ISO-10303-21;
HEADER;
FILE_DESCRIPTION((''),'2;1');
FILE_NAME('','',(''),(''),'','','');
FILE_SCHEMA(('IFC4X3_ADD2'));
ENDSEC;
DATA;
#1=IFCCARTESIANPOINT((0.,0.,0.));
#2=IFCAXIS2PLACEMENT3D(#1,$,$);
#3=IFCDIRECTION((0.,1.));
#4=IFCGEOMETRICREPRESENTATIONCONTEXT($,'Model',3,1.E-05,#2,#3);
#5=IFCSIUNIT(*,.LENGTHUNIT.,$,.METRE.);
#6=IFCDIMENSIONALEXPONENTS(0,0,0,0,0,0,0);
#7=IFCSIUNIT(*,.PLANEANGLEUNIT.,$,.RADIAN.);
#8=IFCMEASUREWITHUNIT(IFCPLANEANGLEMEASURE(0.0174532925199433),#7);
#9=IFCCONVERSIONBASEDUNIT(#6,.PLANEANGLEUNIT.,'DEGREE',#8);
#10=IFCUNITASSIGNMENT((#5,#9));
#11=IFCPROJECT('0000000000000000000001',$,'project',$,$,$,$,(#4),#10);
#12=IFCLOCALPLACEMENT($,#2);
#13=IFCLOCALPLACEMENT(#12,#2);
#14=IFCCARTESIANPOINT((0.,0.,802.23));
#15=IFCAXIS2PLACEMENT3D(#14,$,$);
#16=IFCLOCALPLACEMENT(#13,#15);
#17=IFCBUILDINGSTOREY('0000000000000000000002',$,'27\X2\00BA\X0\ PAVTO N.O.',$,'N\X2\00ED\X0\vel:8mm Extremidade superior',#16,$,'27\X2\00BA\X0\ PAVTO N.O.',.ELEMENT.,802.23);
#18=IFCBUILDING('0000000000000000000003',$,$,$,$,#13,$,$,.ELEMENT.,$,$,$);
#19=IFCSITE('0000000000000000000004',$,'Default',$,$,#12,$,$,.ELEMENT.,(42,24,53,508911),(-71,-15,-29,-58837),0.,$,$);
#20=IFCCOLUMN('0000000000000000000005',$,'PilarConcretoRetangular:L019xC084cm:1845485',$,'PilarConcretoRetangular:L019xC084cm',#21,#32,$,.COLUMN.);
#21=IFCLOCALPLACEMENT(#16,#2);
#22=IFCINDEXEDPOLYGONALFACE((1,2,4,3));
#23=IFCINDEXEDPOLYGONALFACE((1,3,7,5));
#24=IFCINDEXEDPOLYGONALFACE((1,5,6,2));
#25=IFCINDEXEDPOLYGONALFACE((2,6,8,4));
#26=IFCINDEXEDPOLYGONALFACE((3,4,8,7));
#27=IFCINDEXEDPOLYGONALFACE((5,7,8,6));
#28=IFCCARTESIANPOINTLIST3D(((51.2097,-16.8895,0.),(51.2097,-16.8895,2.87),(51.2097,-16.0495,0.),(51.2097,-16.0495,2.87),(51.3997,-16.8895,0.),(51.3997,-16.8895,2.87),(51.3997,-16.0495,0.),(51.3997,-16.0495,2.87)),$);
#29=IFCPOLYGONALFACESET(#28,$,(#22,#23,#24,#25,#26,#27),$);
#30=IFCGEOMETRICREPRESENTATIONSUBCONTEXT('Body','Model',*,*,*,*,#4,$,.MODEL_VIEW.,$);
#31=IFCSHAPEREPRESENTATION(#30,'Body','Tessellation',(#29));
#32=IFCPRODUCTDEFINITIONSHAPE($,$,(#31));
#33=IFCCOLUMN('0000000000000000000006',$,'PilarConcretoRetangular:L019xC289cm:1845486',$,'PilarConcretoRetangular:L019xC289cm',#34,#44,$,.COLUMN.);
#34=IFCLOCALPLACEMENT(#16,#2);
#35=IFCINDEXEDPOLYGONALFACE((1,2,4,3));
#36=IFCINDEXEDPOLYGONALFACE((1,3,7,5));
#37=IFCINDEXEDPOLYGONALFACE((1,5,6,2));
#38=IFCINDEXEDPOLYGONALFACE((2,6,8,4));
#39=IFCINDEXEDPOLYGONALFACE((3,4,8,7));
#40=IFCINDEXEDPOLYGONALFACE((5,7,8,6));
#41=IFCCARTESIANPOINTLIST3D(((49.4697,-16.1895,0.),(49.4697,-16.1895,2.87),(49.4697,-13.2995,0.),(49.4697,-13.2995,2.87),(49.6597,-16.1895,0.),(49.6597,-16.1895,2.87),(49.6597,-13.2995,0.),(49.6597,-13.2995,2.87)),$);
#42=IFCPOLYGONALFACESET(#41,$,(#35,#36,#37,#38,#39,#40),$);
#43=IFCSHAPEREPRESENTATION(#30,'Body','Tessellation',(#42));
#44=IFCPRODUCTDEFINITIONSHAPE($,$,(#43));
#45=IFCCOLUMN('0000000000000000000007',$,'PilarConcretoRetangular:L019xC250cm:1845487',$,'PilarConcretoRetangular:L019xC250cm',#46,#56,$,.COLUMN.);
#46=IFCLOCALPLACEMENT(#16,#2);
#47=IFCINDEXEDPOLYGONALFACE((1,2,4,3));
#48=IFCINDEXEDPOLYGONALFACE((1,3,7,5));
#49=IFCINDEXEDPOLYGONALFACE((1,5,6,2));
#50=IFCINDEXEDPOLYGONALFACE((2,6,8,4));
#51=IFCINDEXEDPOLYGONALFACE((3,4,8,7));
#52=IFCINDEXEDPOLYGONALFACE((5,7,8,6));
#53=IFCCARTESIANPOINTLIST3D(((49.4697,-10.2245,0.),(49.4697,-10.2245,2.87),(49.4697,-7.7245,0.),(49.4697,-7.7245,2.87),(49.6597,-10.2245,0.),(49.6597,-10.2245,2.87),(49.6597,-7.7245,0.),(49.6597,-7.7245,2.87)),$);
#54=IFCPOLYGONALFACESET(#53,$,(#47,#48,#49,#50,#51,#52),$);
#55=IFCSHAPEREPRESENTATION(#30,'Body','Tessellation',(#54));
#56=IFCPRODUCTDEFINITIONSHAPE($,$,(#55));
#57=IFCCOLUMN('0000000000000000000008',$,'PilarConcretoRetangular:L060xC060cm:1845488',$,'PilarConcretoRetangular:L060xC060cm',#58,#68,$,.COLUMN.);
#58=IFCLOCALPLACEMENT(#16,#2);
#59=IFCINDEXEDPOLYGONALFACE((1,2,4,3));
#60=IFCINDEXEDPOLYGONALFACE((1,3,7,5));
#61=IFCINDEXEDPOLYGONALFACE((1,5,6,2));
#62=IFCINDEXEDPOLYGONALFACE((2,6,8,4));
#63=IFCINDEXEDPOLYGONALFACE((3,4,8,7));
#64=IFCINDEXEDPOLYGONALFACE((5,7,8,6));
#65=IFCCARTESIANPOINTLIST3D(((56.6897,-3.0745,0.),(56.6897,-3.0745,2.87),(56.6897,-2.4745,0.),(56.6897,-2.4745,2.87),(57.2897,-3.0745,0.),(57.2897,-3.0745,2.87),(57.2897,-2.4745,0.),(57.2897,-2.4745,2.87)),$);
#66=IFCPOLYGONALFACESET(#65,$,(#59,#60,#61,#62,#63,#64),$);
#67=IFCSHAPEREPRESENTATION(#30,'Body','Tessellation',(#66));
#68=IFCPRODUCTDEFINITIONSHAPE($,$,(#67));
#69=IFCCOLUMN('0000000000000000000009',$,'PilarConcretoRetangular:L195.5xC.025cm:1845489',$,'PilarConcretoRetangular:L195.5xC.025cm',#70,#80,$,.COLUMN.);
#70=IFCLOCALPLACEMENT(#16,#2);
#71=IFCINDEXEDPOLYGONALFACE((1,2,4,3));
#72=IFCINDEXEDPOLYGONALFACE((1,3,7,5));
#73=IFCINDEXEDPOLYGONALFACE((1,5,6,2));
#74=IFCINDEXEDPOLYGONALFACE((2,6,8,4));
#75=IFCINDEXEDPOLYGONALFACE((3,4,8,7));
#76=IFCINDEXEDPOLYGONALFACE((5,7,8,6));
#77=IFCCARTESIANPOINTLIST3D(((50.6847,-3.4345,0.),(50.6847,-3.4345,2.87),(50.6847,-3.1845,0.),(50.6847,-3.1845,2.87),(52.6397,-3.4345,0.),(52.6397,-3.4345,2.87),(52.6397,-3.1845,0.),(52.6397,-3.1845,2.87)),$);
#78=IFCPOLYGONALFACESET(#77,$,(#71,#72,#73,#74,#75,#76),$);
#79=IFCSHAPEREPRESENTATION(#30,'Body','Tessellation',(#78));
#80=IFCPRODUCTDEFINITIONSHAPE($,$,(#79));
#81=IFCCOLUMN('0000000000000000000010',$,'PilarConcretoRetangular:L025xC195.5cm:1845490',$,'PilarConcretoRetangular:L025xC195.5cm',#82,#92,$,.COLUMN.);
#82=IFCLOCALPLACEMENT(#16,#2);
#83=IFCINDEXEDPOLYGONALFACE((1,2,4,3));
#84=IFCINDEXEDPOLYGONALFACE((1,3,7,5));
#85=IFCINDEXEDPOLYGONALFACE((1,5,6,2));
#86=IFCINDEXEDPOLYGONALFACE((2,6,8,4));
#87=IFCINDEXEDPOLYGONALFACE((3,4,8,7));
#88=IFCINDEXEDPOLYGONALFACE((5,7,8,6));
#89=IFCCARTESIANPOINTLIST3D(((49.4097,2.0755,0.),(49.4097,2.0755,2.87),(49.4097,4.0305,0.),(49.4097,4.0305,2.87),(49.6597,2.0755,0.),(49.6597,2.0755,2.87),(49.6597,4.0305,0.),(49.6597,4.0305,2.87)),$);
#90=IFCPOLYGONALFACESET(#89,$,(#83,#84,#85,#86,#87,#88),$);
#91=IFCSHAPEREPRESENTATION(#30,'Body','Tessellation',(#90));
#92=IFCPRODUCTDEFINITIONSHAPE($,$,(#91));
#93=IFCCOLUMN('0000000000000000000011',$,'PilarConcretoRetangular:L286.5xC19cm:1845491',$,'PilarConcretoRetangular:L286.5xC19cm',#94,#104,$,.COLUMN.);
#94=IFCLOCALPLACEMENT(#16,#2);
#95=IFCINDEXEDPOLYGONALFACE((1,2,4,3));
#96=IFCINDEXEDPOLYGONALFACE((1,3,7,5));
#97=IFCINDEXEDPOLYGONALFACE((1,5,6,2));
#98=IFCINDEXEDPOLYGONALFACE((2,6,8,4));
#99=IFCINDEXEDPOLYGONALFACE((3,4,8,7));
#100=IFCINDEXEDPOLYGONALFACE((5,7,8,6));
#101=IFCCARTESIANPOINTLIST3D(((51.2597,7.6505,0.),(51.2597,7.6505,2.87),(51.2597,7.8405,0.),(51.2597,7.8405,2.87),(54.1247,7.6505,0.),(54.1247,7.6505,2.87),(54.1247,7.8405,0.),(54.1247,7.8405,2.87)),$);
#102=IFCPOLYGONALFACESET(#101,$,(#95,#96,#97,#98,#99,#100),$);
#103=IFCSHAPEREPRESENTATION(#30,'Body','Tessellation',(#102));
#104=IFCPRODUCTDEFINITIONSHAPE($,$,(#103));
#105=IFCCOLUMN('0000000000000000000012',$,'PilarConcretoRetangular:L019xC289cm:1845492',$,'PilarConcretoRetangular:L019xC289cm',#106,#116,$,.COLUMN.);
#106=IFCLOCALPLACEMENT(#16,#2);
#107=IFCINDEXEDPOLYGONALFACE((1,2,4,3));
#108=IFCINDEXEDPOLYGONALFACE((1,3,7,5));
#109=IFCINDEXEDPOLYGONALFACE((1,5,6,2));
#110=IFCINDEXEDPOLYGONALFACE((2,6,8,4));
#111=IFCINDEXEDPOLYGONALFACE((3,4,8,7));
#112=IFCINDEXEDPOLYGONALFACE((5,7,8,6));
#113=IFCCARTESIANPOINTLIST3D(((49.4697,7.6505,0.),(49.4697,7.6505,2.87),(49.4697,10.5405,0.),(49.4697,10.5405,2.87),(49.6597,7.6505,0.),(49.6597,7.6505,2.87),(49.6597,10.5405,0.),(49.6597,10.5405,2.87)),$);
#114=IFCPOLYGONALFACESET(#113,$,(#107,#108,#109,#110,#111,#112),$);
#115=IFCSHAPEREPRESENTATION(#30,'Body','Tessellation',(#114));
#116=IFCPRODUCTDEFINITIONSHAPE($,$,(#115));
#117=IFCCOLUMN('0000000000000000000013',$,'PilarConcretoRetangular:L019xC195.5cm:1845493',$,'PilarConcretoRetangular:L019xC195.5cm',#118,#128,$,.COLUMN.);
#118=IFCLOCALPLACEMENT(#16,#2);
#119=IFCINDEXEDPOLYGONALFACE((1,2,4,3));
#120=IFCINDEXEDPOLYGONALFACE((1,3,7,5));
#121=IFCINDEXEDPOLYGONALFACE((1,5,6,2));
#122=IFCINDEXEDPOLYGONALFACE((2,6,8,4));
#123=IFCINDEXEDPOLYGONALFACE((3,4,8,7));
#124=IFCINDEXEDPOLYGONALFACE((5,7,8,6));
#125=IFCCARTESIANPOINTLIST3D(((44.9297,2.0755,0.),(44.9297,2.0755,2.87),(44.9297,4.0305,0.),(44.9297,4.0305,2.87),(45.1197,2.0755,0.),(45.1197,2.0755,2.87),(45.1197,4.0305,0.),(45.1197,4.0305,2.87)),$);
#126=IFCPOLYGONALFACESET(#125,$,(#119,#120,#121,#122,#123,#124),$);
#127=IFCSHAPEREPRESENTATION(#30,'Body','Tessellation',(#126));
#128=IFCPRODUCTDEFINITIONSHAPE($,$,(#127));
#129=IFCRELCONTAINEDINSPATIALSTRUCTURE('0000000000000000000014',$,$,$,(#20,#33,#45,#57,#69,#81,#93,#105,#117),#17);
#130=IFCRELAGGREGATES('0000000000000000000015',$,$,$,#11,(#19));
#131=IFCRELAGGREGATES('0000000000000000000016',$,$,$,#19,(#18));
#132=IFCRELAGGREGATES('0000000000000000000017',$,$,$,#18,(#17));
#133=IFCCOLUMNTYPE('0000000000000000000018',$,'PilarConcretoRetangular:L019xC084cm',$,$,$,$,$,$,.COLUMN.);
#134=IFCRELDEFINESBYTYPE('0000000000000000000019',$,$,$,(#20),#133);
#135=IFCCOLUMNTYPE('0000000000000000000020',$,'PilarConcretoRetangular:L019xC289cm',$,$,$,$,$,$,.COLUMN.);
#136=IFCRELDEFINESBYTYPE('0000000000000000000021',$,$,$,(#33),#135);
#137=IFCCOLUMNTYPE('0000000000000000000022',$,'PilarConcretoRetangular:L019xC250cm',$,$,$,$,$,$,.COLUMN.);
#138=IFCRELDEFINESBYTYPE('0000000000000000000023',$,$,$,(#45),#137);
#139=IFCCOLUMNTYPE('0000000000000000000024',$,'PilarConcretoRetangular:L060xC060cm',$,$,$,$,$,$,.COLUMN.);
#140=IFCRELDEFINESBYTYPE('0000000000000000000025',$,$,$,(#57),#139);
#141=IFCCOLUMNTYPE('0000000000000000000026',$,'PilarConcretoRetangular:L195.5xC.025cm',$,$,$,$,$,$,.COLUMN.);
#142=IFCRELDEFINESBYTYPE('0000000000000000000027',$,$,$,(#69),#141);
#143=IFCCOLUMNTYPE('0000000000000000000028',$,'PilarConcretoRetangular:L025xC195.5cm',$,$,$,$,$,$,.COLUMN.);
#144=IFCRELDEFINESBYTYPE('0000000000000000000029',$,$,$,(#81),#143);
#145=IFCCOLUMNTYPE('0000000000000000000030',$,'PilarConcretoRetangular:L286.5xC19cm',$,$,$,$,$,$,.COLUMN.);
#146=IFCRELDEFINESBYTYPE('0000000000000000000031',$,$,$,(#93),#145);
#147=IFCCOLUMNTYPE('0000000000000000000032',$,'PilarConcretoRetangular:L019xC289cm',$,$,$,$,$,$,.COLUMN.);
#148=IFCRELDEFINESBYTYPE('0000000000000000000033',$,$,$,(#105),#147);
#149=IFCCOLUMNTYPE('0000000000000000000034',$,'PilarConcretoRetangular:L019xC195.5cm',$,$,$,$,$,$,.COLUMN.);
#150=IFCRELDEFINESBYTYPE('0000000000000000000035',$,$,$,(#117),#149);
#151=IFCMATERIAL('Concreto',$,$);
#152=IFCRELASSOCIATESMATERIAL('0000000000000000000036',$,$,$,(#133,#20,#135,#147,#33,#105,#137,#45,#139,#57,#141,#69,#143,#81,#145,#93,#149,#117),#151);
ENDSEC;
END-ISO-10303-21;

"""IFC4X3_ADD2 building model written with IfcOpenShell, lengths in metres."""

from ifc_helpers import new_model, entity, si_unit, converted_unit, direction, frame, frame_2d, origin, origin_2d_with_axis, place, context, subcontext, project, spatial, rectangle, extrude, source, transform, mapped, material, material_profile, profile_set, profile_usage, type_object, type_shapes, element, save


model = new_model("IFC4X3_ADD2")

# Units and contexts
model_context = context("Model", 3, precision=1e-05, world=origin(), true_north=direction((0.0, 1.0)))
body_context = subcontext(model_context, "Body", "Model", "MODEL_VIEW")
ifc_project = project(units=[si_unit("LENGTHUNIT", "METRE"), converted_unit("PLANEANGLEUNIT", "DEGREE", entity("IfcPlaneAngleMeasure", 0.0174532925199433), si_unit("PLANEANGLEUNIT", "RADIAN"), dimensions=[0, 0, 0, 0, 0, 0, 0])], contexts=[model_context])

# Site, building, storey
site_placement = place(None, origin())
site = spatial("IfcSite", under=ifc_project, at=site_placement, Name="Default", CompositionType="ELEMENT", RefLatitude=(42, 24, 53, 508911), RefLongitude=(-71, -15, -29, -58837), RefElevation=0.0)
building_placement = place(site_placement, origin())
building = spatial("IfcBuilding", under=site, at=building_placement, CompositionType="ELEMENT")
storey_placement = place(building_placement, frame((0.0, 0.0, 802.23)))
storey = spatial("IfcBuildingStorey", under=building, at=storey_placement, Name="27º PAVTO N.O.", ObjectType="Nível:8mm Extremidade superior", LongName="27º PAVTO N.O.", CompositionType="ELEMENT", Elevation=802.23)

# Columns
ifc_material = material(Name="Concreto")
ifc_material_profile_1 = material_profile(ifc_material, rectangle(XDim=0.19, YDim=0.84, at=frame_2d((0.0, 0.0), x_axis=(1.0, 0.0))), Name="L019xC084cm")
ifc_profile_set_1 = profile_set([ifc_material_profile_1], Name="L019xC084cm")
ifc_profile_usage_1 = profile_usage(ifc_profile_set_1)
column_type_1 = type_object("IfcColumnType", Name="PilarConcretoRetangular:L019xC084cm", PredefinedType="COLUMN", material=ifc_profile_set_1)
shared_shape_1 = source(origin(), body_context, "Body", "SweptSolid", [
    extrude(rectangle(XDim=0.19, YDim=0.84, at=frame_2d((0.0, 0.0), x_axis=(1.0, 0.0))), frame((51.3047, -16.4695, 802.23), z_axis=(0.0, 0.0, 1.0), x_axis=(-1.0, 0.0, 0.0)), (0.0, 0.0, 1.0), 2.87),
])
type_shapes(column_type_1, [shared_shape_1])
column_1_placement = place(storey_placement, frame((0.0, 0.0, -802.23)))
element("IfcColumn", 1, at=column_1_placement, inside=storey, type_object=column_type_1, material=ifc_profile_usage_1, Name="PilarConcretoRetangular:L019xC084cm:1845485", ObjectType="PilarConcretoRetangular:L019xC084cm", PredefinedType="COLUMN", context=body_context, shape_type="MappedRepresentation", body=[
    mapped(shared_shape_1, transform((0.0, 0.0, 0.0), scale=1.0)),
])
ifc_material_profile_2 = material_profile(ifc_material, rectangle(XDim=0.19, YDim=2.89, at=frame_2d((0.0, 0.0), x_axis=(1.0, 0.0))), Name="L019xC289cm")
ifc_profile_set_2 = profile_set([ifc_material_profile_2], Name="L019xC289cm")
ifc_profile_usage_2 = profile_usage(ifc_profile_set_2)
column_type_2 = type_object("IfcColumnType", Name="PilarConcretoRetangular:L019xC289cm", PredefinedType="COLUMN", material=ifc_profile_set_2)
shared_shape_2 = source(origin(), body_context, "Body", "SweptSolid", [
    extrude(rectangle(XDim=0.19, YDim=2.89, at=frame_2d((0.0, 0.0), x_axis=(1.0, 0.0))), frame((49.5647, -14.7445, 802.23), z_axis=(0.0, 0.0, 1.0), x_axis=(-1.0, 0.0, 0.0)), (0.0, 0.0, 1.0), 2.87),
])
type_shapes(column_type_2, [shared_shape_2])
column_2_placement = place(storey_placement, frame((0.0, 0.0, -802.23)))
element("IfcColumn", 2, at=column_2_placement, inside=storey, type_object=column_type_2, material=ifc_profile_usage_2, Name="PilarConcretoRetangular:L019xC289cm:1845486", ObjectType="PilarConcretoRetangular:L019xC289cm", PredefinedType="COLUMN", context=body_context, shape_type="MappedRepresentation", body=[
    mapped(shared_shape_2, transform((0.0, 0.0, 0.0), scale=1.0)),
])
ifc_material_profile_3 = material_profile(ifc_material, rectangle(XDim=0.19, YDim=2.5, at=frame_2d((0.0, 0.0), x_axis=(1.0, 0.0))), Name="L019xC250cm")
ifc_profile_set_3 = profile_set([ifc_material_profile_3], Name="L019xC250cm")
ifc_profile_usage_3 = profile_usage(ifc_profile_set_3)
column_type_3 = type_object("IfcColumnType", Name="PilarConcretoRetangular:L019xC250cm", PredefinedType="COLUMN", material=ifc_profile_set_3)
shared_shape_3 = source(origin(), body_context, "Body", "SweptSolid", [
    extrude(rectangle(XDim=0.19, YDim=2.5, at=frame_2d((0.0, 0.0), x_axis=(1.0, 0.0))), frame((49.5647, -8.9745, 802.23), z_axis=(0.0, 0.0, 1.0), x_axis=(-1.0, 0.0, 0.0)), (0.0, 0.0, 1.0), 2.87),
])
type_shapes(column_type_3, [shared_shape_3])
column_3_placement = place(storey_placement, frame((0.0, 0.0, -802.23)))
element("IfcColumn", 3, at=column_3_placement, inside=storey, type_object=column_type_3, material=ifc_profile_usage_3, Name="PilarConcretoRetangular:L019xC250cm:1845487", ObjectType="PilarConcretoRetangular:L019xC250cm", PredefinedType="COLUMN", context=body_context, shape_type="MappedRepresentation", body=[
    mapped(shared_shape_3, transform((0.0, 0.0, 0.0), scale=1.0)),
])
ifc_material_profile_4 = material_profile(ifc_material, rectangle(XDim=0.6, YDim=0.6, at=origin_2d_with_axis()), Name="L060xC060cm")
ifc_profile_set_4 = profile_set([ifc_material_profile_4], Name="L060xC060cm")
ifc_profile_usage_4 = profile_usage(ifc_profile_set_4)
column_type_4 = type_object("IfcColumnType", Name="PilarConcretoRetangular:L060xC060cm", PredefinedType="COLUMN", material=ifc_profile_set_4)
shared_shape_4 = source(origin(), body_context, "Body", "SweptSolid", [
    extrude(rectangle(XDim=0.6, YDim=0.6, at=origin_2d_with_axis()), frame((56.9897, -2.7745, 802.23), z_axis=(0.0, 0.0, 1.0), x_axis=(-1.0, 0.0, 0.0)), (0.0, 0.0, 1.0), 2.87),
])
type_shapes(column_type_4, [shared_shape_4])
column_4_placement = place(storey_placement, frame((0.0, 0.0, -802.23)))
element("IfcColumn", 4, at=column_4_placement, inside=storey, type_object=column_type_4, material=ifc_profile_usage_4, Name="PilarConcretoRetangular:L060xC060cm:1845488", ObjectType="PilarConcretoRetangular:L060xC060cm", PredefinedType="COLUMN", context=body_context, shape_type="MappedRepresentation", body=[
    mapped(shared_shape_4, transform((0.0, 0.0, 0.0), scale=1.0)),
])
ifc_material_profile_5 = material_profile(ifc_material, rectangle(XDim=1.955, YDim=0.25, at=frame_2d((0.0, 0.0), x_axis=(1.0, 0.0))), Name="L195.5xC.025cm")
ifc_profile_set_5 = profile_set([ifc_material_profile_5], Name="L195.5xC.025cm")
ifc_profile_usage_5 = profile_usage(ifc_profile_set_5)
column_type_5 = type_object("IfcColumnType", Name="PilarConcretoRetangular:L195.5xC.025cm", PredefinedType="COLUMN", material=ifc_profile_set_5)
shared_shape_5 = source(origin(), body_context, "Body", "SweptSolid", [
    extrude(rectangle(XDim=1.955, YDim=0.25, at=frame_2d((0.0, 0.0), x_axis=(1.0, 0.0))), frame((51.6622, -3.3095, 802.23), z_axis=(0.0, 0.0, 1.0), x_axis=(-1.0, 0.0, 0.0)), (0.0, 0.0, 1.0), 2.87),
])
type_shapes(column_type_5, [shared_shape_5])
column_5_placement = place(storey_placement, frame((0.0, 0.0, -802.23)))
element("IfcColumn", 5, at=column_5_placement, inside=storey, type_object=column_type_5, material=ifc_profile_usage_5, Name="PilarConcretoRetangular:L195.5xC.025cm:1845489", ObjectType="PilarConcretoRetangular:L195.5xC.025cm", PredefinedType="COLUMN", context=body_context, shape_type="MappedRepresentation", body=[
    mapped(shared_shape_5, transform((0.0, 0.0, 0.0), scale=1.0)),
])
ifc_material_profile_6 = material_profile(ifc_material, rectangle(XDim=0.25, YDim=1.955, at=frame_2d((0.0, 0.0), x_axis=(1.0, 0.0))), Name="L025xC195.5cm")
ifc_profile_set_6 = profile_set([ifc_material_profile_6], Name="L025xC195.5cm")
ifc_profile_usage_6 = profile_usage(ifc_profile_set_6)
column_type_6 = type_object("IfcColumnType", Name="PilarConcretoRetangular:L025xC195.5cm", PredefinedType="COLUMN", material=ifc_profile_set_6)
shared_shape_6 = source(origin(), body_context, "Body", "SweptSolid", [
    extrude(rectangle(XDim=0.25, YDim=1.955, at=frame_2d((0.0, 0.0), x_axis=(1.0, 0.0))), frame((49.5347, 3.053, 802.23), z_axis=(0.0, 0.0, 1.0), x_axis=(-1.0, 0.0, 0.0)), (0.0, 0.0, 1.0), 2.87),
])
type_shapes(column_type_6, [shared_shape_6])
column_6_placement = place(storey_placement, frame((0.0, 0.0, -802.23)))
element("IfcColumn", 6, at=column_6_placement, inside=storey, type_object=column_type_6, material=ifc_profile_usage_6, Name="PilarConcretoRetangular:L025xC195.5cm:1845490", ObjectType="PilarConcretoRetangular:L025xC195.5cm", PredefinedType="COLUMN", context=body_context, shape_type="MappedRepresentation", body=[
    mapped(shared_shape_6, transform((0.0, 0.0, 0.0), scale=1.0)),
])
ifc_material_profile_7 = material_profile(ifc_material, rectangle(XDim=2.865, YDim=0.19, at=frame_2d((0.0, 0.0), x_axis=(1.0, 0.0))), Name="L286.5xC19cm")
ifc_profile_set_7 = profile_set([ifc_material_profile_7], Name="L286.5xC19cm")
ifc_profile_usage_7 = profile_usage(ifc_profile_set_7)
column_type_7 = type_object("IfcColumnType", Name="PilarConcretoRetangular:L286.5xC19cm", PredefinedType="COLUMN", material=ifc_profile_set_7)
shared_shape_7 = source(origin(), body_context, "Body", "SweptSolid", [
    extrude(rectangle(XDim=2.865, YDim=0.19, at=frame_2d((0.0, 0.0), x_axis=(1.0, 0.0))), frame((52.6922, 7.7455, 802.23), z_axis=(0.0, 0.0, 1.0), x_axis=(-1.0, 0.0, 0.0)), (0.0, 0.0, 1.0), 2.87),
])
type_shapes(column_type_7, [shared_shape_7])
column_7_placement = place(storey_placement, frame((0.0, 0.0, -802.23)))
element("IfcColumn", 7, at=column_7_placement, inside=storey, type_object=column_type_7, material=ifc_profile_usage_7, Name="PilarConcretoRetangular:L286.5xC19cm:1845491", ObjectType="PilarConcretoRetangular:L286.5xC19cm", PredefinedType="COLUMN", context=body_context, shape_type="MappedRepresentation", body=[
    mapped(shared_shape_7, transform((0.0, 0.0, 0.0), scale=1.0)),
])
column_type_8 = type_object("IfcColumnType", Name="PilarConcretoRetangular:L019xC289cm", PredefinedType="COLUMN", material=ifc_profile_set_2)
shared_shape_8 = source(origin(), body_context, "Body", "SweptSolid", [
    extrude(rectangle(XDim=0.19, YDim=2.89, at=frame_2d((0.0, 0.0), x_axis=(1.0, 0.0))), frame((49.5647, 9.0955, 802.23), z_axis=(0.0, 0.0, 1.0), x_axis=(-1.0, 0.0, 0.0)), (0.0, 0.0, 1.0), 2.87),
])
type_shapes(column_type_8, [shared_shape_8])
column_8_placement = place(storey_placement, frame((0.0, 0.0, -802.23)))
element("IfcColumn", 8, at=column_8_placement, inside=storey, type_object=column_type_8, material=ifc_profile_usage_2, Name="PilarConcretoRetangular:L019xC289cm:1845492", ObjectType="PilarConcretoRetangular:L019xC289cm", PredefinedType="COLUMN", context=body_context, shape_type="MappedRepresentation", body=[
    mapped(shared_shape_8, transform((0.0, 0.0, 0.0), scale=1.0)),
])
ifc_material_profile_8 = material_profile(ifc_material, rectangle(XDim=0.19, YDim=1.955, at=frame_2d((0.0, 0.0), x_axis=(1.0, 0.0))), Name="L019xC195.5cm")
ifc_profile_set_8 = profile_set([ifc_material_profile_8], Name="L019xC195.5cm")
ifc_profile_usage_8 = profile_usage(ifc_profile_set_8)
column_type_9 = type_object("IfcColumnType", Name="PilarConcretoRetangular:L019xC195.5cm", PredefinedType="COLUMN", material=ifc_profile_set_8)
shared_shape_9 = source(origin(), body_context, "Body", "SweptSolid", [
    extrude(rectangle(XDim=0.19, YDim=1.955, at=frame_2d((0.0, 0.0), x_axis=(1.0, 0.0))), frame((45.0247, 3.053, 802.23), z_axis=(0.0, 0.0, 1.0), x_axis=(-1.0, 0.0, 0.0)), (0.0, 0.0, 1.0), 2.87),
])
type_shapes(column_type_9, [shared_shape_9])
column_9_placement = place(storey_placement, frame((0.0, 0.0, -802.23)))
element("IfcColumn", 9, at=column_9_placement, inside=storey, type_object=column_type_9, material=ifc_profile_usage_8, Name="PilarConcretoRetangular:L019xC195.5cm:1845493", ObjectType="PilarConcretoRetangular:L019xC195.5cm", PredefinedType="COLUMN", context=body_context, shape_type="MappedRepresentation", body=[
    mapped(shared_shape_9, transform((0.0, 0.0, 0.0), scale=1.0)),
])

save(model, "model.ifc")
